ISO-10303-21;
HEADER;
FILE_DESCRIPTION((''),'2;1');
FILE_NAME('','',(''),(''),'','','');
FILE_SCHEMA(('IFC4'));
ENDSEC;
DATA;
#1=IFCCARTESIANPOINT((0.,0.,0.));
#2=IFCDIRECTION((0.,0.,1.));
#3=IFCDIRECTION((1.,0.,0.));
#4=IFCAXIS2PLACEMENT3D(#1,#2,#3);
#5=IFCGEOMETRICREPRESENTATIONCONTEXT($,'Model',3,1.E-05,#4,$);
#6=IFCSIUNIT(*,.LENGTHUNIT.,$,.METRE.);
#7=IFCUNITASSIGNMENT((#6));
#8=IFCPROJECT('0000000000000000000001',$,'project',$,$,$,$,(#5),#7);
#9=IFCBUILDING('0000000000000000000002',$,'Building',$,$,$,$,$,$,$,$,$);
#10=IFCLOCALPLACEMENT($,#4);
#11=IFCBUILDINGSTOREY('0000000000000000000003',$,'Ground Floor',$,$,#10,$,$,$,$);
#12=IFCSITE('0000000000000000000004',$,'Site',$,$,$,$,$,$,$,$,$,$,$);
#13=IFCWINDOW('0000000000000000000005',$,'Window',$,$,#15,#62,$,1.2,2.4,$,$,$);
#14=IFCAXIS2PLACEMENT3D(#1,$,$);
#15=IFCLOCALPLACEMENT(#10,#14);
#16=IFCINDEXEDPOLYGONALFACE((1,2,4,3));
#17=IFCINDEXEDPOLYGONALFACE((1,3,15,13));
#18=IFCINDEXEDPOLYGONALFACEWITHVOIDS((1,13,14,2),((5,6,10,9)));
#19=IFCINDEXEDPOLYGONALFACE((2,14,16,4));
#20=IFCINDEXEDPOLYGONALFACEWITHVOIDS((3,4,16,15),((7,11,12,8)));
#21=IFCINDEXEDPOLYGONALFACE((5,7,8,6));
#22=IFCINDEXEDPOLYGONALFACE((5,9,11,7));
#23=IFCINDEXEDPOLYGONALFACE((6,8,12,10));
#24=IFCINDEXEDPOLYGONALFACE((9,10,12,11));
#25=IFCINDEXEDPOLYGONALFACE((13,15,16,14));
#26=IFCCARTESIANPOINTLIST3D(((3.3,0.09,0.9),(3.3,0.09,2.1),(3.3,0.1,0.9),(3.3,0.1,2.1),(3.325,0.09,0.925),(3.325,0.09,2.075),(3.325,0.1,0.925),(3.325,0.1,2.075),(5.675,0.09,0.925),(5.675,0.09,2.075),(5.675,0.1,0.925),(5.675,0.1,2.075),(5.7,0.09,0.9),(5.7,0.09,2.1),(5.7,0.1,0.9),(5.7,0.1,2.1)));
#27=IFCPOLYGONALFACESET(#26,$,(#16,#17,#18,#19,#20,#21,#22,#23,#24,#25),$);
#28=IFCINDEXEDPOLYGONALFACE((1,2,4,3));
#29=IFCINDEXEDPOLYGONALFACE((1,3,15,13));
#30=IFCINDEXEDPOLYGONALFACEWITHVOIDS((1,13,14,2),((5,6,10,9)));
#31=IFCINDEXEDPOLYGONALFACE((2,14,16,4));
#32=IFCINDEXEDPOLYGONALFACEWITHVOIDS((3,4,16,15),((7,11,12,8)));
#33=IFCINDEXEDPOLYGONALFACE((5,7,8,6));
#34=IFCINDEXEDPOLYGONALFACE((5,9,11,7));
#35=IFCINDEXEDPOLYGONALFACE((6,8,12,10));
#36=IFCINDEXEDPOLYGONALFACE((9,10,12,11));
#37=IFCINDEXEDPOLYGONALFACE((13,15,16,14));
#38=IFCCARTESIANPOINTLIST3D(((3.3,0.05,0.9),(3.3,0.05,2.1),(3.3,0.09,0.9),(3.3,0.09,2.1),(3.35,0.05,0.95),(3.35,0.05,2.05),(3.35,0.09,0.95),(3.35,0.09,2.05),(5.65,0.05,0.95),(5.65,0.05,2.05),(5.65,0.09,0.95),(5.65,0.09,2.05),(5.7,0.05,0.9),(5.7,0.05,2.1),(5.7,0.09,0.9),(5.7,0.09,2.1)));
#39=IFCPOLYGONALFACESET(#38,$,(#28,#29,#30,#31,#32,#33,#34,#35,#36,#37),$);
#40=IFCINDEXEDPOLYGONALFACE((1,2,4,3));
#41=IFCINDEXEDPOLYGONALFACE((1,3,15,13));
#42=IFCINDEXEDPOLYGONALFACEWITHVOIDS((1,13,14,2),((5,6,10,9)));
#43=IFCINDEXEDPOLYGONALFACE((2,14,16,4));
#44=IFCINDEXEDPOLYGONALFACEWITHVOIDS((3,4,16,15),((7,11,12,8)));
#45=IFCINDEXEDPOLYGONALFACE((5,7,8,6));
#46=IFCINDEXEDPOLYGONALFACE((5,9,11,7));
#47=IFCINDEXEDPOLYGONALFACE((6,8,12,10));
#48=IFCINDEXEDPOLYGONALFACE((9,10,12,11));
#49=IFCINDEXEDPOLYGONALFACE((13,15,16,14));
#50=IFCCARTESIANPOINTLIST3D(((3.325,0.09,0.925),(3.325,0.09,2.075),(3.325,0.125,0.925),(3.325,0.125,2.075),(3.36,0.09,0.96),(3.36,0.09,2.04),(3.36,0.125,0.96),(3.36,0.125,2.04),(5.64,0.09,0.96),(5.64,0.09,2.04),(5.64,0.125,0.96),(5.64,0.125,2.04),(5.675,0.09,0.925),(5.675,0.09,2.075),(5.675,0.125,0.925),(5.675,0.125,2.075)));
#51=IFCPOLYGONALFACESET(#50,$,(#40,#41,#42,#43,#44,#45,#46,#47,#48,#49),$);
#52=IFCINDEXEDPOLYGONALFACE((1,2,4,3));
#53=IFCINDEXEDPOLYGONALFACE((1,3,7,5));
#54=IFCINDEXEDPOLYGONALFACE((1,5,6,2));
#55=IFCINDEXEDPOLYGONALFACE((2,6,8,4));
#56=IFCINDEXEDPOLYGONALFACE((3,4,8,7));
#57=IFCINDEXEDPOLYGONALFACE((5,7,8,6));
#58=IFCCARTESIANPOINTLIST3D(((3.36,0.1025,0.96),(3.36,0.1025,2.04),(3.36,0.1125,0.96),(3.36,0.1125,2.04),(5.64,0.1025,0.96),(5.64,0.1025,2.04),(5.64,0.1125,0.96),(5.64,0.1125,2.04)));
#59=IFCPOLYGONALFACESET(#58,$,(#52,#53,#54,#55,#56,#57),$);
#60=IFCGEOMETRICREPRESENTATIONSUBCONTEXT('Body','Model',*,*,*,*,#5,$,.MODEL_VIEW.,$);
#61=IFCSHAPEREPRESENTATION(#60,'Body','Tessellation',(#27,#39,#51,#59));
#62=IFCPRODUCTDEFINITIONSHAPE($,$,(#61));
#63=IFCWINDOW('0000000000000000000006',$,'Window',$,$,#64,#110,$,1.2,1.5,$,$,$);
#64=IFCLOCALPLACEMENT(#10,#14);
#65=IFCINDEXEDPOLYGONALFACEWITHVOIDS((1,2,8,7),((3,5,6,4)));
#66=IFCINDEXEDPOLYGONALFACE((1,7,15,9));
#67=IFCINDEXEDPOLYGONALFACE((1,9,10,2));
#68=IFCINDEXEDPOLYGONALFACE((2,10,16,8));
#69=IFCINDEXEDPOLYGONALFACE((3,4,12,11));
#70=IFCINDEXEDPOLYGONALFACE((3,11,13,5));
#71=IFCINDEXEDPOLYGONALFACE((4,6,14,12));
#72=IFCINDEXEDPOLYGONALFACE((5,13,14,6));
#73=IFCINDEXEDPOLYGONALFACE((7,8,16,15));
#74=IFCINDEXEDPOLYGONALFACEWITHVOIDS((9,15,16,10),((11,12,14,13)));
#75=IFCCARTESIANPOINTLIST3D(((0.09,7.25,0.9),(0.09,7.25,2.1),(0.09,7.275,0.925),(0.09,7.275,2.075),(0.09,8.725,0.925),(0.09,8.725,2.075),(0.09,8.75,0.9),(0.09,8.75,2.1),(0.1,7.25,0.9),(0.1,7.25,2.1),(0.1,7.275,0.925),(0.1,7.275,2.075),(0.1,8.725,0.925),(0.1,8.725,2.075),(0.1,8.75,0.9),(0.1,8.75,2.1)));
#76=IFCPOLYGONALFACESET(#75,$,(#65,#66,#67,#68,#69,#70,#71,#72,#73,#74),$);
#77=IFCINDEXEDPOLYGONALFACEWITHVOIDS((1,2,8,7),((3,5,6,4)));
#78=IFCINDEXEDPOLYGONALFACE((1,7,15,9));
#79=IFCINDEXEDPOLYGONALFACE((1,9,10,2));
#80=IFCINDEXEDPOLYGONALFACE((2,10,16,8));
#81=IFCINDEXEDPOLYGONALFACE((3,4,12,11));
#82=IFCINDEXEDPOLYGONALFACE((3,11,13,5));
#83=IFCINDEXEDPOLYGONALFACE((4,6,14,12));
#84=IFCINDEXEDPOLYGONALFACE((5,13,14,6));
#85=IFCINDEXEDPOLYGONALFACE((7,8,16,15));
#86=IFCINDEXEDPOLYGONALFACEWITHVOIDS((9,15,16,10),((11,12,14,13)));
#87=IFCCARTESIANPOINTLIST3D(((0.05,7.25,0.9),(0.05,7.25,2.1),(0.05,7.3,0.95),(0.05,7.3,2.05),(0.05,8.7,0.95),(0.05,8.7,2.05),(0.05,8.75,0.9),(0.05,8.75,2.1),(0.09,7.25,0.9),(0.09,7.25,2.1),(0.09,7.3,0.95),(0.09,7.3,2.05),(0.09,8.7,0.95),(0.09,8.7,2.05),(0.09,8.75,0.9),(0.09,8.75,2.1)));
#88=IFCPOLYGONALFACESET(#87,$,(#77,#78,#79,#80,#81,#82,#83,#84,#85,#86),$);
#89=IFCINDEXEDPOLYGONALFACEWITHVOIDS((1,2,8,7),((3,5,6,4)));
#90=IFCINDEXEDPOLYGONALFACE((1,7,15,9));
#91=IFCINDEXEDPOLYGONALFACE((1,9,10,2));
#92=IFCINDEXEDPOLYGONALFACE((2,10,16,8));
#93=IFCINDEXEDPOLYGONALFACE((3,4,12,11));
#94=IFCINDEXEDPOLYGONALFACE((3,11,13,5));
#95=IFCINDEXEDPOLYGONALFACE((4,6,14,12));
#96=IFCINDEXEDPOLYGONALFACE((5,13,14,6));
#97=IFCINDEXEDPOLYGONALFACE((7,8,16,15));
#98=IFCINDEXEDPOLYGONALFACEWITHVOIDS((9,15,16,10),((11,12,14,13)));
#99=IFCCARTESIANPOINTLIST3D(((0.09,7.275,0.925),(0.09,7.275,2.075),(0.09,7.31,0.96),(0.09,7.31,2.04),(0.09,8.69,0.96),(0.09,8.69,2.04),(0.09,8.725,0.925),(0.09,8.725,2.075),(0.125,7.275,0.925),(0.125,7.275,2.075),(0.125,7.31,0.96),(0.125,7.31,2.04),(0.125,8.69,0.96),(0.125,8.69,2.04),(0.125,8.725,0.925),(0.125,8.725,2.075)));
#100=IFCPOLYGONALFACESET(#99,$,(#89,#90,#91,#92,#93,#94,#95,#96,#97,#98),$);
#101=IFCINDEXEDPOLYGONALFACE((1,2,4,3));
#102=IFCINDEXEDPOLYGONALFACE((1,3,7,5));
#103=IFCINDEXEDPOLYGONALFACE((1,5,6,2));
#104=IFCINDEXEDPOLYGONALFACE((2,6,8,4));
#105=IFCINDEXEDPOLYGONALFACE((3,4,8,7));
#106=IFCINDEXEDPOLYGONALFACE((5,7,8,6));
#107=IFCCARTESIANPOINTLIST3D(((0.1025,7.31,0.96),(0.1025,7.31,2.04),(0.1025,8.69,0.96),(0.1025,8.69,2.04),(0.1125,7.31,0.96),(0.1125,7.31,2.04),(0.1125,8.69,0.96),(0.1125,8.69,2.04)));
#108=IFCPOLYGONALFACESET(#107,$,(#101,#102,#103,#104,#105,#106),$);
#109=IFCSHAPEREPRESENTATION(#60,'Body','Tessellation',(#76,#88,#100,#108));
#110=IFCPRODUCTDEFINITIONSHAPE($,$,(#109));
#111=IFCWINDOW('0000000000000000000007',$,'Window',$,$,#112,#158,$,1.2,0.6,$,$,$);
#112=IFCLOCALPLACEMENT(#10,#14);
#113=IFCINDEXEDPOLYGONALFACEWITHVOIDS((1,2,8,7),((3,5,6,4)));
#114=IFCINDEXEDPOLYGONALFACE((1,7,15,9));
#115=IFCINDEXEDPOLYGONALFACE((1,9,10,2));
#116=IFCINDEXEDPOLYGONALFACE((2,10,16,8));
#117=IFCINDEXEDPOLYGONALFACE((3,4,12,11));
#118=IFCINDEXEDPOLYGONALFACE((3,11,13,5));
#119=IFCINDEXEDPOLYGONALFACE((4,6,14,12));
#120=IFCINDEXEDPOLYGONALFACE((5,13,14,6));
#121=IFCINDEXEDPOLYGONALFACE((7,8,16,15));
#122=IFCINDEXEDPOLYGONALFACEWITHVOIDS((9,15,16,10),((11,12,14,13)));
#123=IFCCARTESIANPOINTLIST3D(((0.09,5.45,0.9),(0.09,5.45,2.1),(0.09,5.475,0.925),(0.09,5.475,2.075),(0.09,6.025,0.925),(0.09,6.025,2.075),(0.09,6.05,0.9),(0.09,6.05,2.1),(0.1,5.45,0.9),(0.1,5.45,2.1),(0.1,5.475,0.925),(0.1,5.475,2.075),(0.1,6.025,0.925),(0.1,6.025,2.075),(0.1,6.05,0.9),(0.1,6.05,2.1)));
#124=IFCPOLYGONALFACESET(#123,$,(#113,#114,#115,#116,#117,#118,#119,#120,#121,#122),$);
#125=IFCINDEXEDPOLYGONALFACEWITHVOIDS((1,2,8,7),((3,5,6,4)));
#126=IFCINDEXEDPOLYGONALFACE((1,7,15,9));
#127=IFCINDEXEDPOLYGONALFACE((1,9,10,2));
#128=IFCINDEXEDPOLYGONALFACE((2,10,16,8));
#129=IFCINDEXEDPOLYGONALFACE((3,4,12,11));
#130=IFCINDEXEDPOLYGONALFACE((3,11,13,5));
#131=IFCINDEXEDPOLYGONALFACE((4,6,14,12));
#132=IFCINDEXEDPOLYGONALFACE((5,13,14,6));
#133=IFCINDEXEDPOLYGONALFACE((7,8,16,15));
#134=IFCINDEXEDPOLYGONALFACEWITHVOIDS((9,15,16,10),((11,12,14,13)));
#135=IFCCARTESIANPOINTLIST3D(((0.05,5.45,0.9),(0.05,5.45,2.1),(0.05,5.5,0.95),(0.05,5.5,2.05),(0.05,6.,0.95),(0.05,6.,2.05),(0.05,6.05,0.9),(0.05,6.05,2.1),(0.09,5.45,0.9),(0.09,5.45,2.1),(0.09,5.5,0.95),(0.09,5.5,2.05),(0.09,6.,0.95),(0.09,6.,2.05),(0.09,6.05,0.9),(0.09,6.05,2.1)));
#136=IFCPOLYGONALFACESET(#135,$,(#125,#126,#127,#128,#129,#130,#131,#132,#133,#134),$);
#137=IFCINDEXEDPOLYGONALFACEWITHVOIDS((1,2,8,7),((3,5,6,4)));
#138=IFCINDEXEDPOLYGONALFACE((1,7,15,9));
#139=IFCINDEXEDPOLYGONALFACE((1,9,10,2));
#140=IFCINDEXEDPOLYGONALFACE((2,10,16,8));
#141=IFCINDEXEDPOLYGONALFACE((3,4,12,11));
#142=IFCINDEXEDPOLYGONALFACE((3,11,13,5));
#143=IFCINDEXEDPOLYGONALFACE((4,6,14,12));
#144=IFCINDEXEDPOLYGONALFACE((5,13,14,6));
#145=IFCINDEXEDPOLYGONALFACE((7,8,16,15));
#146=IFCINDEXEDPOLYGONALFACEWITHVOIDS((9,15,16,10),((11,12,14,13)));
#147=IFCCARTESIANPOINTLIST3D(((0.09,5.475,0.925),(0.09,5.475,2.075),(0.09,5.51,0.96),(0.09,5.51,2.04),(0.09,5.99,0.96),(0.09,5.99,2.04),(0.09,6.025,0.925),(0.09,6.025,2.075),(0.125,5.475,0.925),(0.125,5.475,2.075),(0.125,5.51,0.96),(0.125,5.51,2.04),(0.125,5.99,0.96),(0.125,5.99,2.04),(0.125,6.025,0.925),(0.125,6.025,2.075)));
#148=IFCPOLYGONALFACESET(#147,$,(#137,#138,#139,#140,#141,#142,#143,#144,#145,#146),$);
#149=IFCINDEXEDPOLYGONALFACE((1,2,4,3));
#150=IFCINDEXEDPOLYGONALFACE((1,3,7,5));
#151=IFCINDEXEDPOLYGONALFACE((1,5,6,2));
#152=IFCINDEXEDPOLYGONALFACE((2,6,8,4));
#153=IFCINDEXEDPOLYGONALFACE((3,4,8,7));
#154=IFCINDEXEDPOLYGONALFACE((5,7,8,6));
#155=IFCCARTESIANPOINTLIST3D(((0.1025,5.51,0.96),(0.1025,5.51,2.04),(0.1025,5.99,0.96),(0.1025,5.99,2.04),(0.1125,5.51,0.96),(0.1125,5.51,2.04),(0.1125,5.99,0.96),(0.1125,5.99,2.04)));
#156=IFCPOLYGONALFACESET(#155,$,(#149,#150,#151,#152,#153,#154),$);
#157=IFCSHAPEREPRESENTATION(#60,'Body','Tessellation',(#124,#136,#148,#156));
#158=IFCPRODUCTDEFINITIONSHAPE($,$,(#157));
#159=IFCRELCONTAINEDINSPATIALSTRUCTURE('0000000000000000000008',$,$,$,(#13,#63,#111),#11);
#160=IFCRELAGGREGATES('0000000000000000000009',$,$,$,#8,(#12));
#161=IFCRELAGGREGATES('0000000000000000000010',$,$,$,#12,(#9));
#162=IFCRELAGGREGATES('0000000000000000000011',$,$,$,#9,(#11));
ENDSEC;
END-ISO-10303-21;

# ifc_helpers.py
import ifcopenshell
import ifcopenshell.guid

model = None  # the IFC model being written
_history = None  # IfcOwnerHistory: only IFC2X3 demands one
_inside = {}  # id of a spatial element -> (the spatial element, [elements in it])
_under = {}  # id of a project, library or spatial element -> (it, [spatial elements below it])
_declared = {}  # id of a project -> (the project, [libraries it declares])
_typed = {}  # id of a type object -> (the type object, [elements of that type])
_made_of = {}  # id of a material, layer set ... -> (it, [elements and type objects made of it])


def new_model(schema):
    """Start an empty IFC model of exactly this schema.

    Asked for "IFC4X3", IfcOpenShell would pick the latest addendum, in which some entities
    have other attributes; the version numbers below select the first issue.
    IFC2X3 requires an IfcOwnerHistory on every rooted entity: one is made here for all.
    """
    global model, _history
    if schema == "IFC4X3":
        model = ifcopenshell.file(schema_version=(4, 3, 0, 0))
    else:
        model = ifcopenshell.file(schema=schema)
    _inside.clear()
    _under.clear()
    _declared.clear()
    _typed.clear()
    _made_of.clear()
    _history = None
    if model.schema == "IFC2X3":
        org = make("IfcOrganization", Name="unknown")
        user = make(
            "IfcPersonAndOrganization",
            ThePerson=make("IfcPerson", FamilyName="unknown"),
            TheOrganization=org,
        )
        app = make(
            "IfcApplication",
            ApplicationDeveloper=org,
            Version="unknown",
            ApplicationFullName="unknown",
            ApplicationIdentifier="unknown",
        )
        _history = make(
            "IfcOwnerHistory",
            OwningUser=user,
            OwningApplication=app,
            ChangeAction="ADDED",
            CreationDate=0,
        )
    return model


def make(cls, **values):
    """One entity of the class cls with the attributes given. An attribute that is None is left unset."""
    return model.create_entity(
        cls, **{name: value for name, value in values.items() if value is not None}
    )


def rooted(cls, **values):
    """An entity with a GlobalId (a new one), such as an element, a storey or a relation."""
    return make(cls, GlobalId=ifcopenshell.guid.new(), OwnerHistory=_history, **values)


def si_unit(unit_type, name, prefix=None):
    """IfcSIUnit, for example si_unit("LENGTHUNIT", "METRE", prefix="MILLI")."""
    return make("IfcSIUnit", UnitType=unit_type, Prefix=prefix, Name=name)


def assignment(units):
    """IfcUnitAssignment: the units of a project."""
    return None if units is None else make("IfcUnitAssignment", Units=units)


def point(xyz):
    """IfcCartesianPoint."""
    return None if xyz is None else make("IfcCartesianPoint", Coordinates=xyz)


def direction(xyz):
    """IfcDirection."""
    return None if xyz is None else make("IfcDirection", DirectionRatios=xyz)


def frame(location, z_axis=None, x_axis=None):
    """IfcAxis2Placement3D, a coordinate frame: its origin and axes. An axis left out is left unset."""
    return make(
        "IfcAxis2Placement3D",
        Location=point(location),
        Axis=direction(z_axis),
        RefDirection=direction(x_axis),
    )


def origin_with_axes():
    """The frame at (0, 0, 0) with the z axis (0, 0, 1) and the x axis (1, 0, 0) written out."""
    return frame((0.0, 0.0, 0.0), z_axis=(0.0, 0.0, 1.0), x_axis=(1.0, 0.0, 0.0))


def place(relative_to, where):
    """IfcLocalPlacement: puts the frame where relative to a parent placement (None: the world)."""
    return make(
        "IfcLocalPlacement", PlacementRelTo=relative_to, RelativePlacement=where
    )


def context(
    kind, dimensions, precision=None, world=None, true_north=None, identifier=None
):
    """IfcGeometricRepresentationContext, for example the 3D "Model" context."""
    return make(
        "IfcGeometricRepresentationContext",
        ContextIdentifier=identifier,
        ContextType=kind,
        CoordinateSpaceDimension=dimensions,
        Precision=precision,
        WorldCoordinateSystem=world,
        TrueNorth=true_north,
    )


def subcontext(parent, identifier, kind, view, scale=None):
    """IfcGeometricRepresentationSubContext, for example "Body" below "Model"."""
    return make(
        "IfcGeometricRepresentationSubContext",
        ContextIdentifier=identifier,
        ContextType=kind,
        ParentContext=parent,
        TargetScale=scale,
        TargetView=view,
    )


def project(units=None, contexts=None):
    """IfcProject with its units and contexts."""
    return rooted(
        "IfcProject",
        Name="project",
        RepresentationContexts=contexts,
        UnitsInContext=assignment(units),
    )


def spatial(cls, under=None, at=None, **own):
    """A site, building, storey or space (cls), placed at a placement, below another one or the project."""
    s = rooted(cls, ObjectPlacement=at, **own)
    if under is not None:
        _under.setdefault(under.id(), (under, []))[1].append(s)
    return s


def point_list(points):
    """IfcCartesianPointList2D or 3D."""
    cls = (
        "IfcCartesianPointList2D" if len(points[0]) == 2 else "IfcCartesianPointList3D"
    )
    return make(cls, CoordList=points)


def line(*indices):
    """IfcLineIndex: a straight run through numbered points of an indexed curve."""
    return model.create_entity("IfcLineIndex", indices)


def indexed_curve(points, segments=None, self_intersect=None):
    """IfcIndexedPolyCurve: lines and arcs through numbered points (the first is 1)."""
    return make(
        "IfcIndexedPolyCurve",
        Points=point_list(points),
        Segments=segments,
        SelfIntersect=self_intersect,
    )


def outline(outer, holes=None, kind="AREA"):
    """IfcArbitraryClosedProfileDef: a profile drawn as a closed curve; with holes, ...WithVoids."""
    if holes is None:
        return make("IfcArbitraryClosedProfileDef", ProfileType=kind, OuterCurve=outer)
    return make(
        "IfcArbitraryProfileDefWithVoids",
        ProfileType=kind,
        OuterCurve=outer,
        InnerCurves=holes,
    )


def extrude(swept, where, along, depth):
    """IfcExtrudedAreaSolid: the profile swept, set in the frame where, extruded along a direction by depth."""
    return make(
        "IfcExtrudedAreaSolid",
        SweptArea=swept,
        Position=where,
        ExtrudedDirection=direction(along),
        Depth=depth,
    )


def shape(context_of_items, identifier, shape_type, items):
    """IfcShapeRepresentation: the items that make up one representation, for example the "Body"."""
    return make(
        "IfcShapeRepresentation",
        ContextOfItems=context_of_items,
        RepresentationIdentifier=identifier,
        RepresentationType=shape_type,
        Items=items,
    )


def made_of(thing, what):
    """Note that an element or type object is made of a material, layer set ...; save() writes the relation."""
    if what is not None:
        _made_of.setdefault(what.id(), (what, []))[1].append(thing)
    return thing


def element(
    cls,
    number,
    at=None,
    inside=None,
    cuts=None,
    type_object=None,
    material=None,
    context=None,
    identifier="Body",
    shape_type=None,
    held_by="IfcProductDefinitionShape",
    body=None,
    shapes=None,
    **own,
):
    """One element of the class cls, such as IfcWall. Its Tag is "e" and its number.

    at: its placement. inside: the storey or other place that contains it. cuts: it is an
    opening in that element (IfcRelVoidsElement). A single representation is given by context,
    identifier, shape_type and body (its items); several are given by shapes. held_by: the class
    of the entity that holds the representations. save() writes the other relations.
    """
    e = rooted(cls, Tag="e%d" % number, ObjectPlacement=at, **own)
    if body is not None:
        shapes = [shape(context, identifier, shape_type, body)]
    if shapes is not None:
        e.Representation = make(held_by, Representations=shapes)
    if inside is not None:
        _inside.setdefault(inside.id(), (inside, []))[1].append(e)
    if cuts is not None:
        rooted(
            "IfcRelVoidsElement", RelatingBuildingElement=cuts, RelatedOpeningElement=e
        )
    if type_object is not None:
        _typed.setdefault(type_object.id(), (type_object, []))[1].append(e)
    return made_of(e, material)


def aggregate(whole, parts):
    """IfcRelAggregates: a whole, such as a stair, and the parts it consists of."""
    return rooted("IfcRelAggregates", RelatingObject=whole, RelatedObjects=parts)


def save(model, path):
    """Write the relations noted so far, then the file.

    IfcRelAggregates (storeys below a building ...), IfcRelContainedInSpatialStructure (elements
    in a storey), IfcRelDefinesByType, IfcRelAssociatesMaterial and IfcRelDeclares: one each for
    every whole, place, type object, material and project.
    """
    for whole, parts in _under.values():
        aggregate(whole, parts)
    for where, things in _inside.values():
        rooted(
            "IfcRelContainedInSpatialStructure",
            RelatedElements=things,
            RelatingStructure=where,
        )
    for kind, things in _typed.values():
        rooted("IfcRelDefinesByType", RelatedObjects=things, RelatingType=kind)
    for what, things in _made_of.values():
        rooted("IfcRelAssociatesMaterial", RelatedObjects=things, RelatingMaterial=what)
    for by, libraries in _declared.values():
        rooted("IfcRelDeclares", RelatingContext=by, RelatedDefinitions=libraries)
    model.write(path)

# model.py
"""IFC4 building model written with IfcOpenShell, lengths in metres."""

from ifc_helpers import new_model, si_unit, frame, origin_with_axes, place, context, subcontext, project, spatial, line, indexed_curve, outline, extrude, element, save


model = new_model("IFC4")

# Units and contexts
model_context = context("Model", 3, precision=1e-05, world=origin_with_axes())
body_context = subcontext(model_context, "Body", "Model", "MODEL_VIEW")
ifc_project = project(units=[si_unit("LENGTHUNIT", "METRE")], contexts=[model_context])

# Site, building, storey
site = spatial("IfcSite", under=ifc_project, Name="Site")
building = spatial("IfcBuilding", under=site, Name="Building")
storey_placement = place(None, origin_with_axes())
storey = spatial("IfcBuildingStorey", under=building, at=storey_placement, Name="Ground Floor")

# Windows
window_1_placement = place(storey_placement, frame((3.3, 0.0, 0.9), z_axis=(0.0, 0.0, 1.0), x_axis=(1.0, 0.0, 0.0)))
element("IfcWindow", 1, at=window_1_placement, inside=storey, Name="Window", OverallHeight=1.2, OverallWidth=2.4, context=body_context, shape_type="SweptSolid", body=[
    extrude(outline(indexed_curve([(0.0, 0.0), (2.4, 0.0), (2.4, 1.2), (0.0, 1.2)], segments=[line(1, 2, 3, 4, 1)]), holes=[indexed_curve([(0.025, 0.025), (2.375, 0.025), (2.375, 1.175), (0.025, 1.175)], segments=[line(1, 2, 3, 4, 1)])]), frame((0.0, 0.09, 0.0), z_axis=(0.0, -1.0, 0.0), x_axis=(1.0, 0.0, 0.0)), (0.0, 0.0, -1.0), 0.01),
    extrude(outline(indexed_curve([(0.0, 0.0), (2.4, 0.0), (2.4, 1.2), (0.0, 1.2)], segments=[line(1, 2, 3, 4, 1)]), holes=[indexed_curve([(0.05, 0.05), (2.35, 0.05), (2.35, 1.15), (0.05, 1.15)], segments=[line(1, 2, 3, 4, 1)])]), frame((0.0, 0.05, 0.0), z_axis=(0.0, -1.0, 0.0), x_axis=(1.0, 0.0, 0.0)), (0.0, 0.0, -1.0), 0.04),
    extrude(outline(indexed_curve([(0.0, 0.0), (2.35, 0.0), (2.35, 1.15), (0.0, 1.15)], segments=[line(1, 2, 3, 4, 1)]), holes=[indexed_curve([(0.035, 0.035), (2.315, 0.035), (2.315, 1.115), (0.035, 1.115)], segments=[line(1, 2, 3, 4, 1)])]), frame((0.025, 0.09, 0.025), z_axis=(0.0, -1.0, 0.0), x_axis=(1.0, 0.0, 0.0)), (0.0, 0.0, -1.0), 0.035),
    extrude(outline(indexed_curve([(0.035, 0.035), (2.315, 0.035), (2.315, 1.115), (0.035, 1.115)], segments=[line(1, 2, 3, 4, 1)])), frame((0.025, 0.1025, 0.025), z_axis=(0.0, -1.0, 0.0), x_axis=(1.0, 0.0, 0.0)), (0.0, 0.0, -1.0), 0.01),
])
window_2_placement = place(storey_placement, frame((0.0, 8.75, 0.9), z_axis=(0.0, 0.0, 1.0), x_axis=(0.0, -1.0, 0.0)))
element("IfcWindow", 2, at=window_2_placement, inside=storey, Name="Window", OverallHeight=1.2, OverallWidth=1.5, context=body_context, shape_type="SweptSolid", body=[
    extrude(outline(indexed_curve([(0.0, 0.0), (1.5, 0.0), (1.5, 1.2), (0.0, 1.2)], segments=[line(1, 2, 3, 4, 1)]), holes=[indexed_curve([(0.025, 0.025), (1.475, 0.025), (1.475, 1.175), (0.025, 1.175)], segments=[line(1, 2, 3, 4, 1)])]), frame((0.0, 0.09, 0.0), z_axis=(0.0, -1.0, 0.0), x_axis=(1.0, 0.0, 0.0)), (0.0, 0.0, -1.0), 0.01),
    extrude(outline(indexed_curve([(0.0, 0.0), (1.5, 0.0), (1.5, 1.2), (0.0, 1.2)], segments=[line(1, 2, 3, 4, 1)]), holes=[indexed_curve([(0.05, 0.05), (1.45, 0.05), (1.45, 1.15), (0.05, 1.15)], segments=[line(1, 2, 3, 4, 1)])]), frame((0.0, 0.05, 0.0), z_axis=(0.0, -1.0, 0.0), x_axis=(1.0, 0.0, 0.0)), (0.0, 0.0, -1.0), 0.04),
    extrude(outline(indexed_curve([(0.0, 0.0), (1.45, 0.0), (1.45, 1.15), (0.0, 1.15)], segments=[line(1, 2, 3, 4, 1)]), holes=[indexed_curve([(0.035, 0.035), (1.415, 0.035), (1.415, 1.115), (0.035, 1.115)], segments=[line(1, 2, 3, 4, 1)])]), frame((0.025, 0.09, 0.025), z_axis=(0.0, -1.0, 0.0), x_axis=(1.0, 0.0, 0.0)), (0.0, 0.0, -1.0), 0.035),
    extrude(outline(indexed_curve([(0.035, 0.035), (1.415, 0.035), (1.415, 1.115), (0.035, 1.115)], segments=[line(1, 2, 3, 4, 1)])), frame((0.025, 0.1025, 0.025), z_axis=(0.0, -1.0, 0.0), x_axis=(1.0, 0.0, 0.0)), (0.0, 0.0, -1.0), 0.01),
])
window_3_placement = place(storey_placement, frame((0.0, 6.05, 0.9), z_axis=(0.0, 0.0, 1.0), x_axis=(0.0, -1.0, 0.0)))
element("IfcWindow", 3, at=window_3_placement, inside=storey, Name="Window", OverallHeight=1.2, OverallWidth=0.6, context=body_context, shape_type="SweptSolid", body=[
    extrude(outline(indexed_curve([(0.0, 0.0), (0.6, 0.0), (0.6, 1.2), (0.0, 1.2)], segments=[line(1, 2, 3, 4, 1)]), holes=[indexed_curve([(0.025, 0.025), (0.575, 0.025), (0.575, 1.175), (0.025, 1.175)], segments=[line(1, 2, 3, 4, 1)])]), frame((0.0, 0.09, 0.0), z_axis=(0.0, -1.0, 0.0), x_axis=(1.0, 0.0, 0.0)), (0.0, 0.0, -1.0), 0.01),
    extrude(outline(indexed_curve([(0.0, 0.0), (0.6, 0.0), (0.6, 1.2), (0.0, 1.2)], segments=[line(1, 2, 3, 4, 1)]), holes=[indexed_curve([(0.05, 0.05), (0.55, 0.05), (0.55, 1.15), (0.05, 1.15)], segments=[line(1, 2, 3, 4, 1)])]), frame((0.0, 0.05, 0.0), z_axis=(0.0, -1.0, 0.0), x_axis=(1.0, 0.0, 0.0)), (0.0, 0.0, -1.0), 0.04),
    extrude(outline(indexed_curve([(0.0, 0.0), (0.55, 0.0), (0.55, 1.15), (0.0, 1.15)], segments=[line(1, 2, 3, 4, 1)]), holes=[indexed_curve([(0.035, 0.035), (0.515, 0.035), (0.515, 1.115), (0.035, 1.115)], segments=[line(1, 2, 3, 4, 1)])]), frame((0.025, 0.09, 0.025), z_axis=(0.0, -1.0, 0.0), x_axis=(1.0, 0.0, 0.0)), (0.0, 0.0, -1.0), 0.035),
    extrude(outline(indexed_curve([(0.035, 0.035), (0.515, 0.035), (0.515, 1.115), (0.035, 1.115)], segments=[line(1, 2, 3, 4, 1)])), frame((0.025, 0.1025, 0.025), z_axis=(0.0, -1.0, 0.0), x_axis=(1.0, 0.0, 0.0)), (0.0, 0.0, -1.0), 0.01),
])

save(model, "model.ifc")
